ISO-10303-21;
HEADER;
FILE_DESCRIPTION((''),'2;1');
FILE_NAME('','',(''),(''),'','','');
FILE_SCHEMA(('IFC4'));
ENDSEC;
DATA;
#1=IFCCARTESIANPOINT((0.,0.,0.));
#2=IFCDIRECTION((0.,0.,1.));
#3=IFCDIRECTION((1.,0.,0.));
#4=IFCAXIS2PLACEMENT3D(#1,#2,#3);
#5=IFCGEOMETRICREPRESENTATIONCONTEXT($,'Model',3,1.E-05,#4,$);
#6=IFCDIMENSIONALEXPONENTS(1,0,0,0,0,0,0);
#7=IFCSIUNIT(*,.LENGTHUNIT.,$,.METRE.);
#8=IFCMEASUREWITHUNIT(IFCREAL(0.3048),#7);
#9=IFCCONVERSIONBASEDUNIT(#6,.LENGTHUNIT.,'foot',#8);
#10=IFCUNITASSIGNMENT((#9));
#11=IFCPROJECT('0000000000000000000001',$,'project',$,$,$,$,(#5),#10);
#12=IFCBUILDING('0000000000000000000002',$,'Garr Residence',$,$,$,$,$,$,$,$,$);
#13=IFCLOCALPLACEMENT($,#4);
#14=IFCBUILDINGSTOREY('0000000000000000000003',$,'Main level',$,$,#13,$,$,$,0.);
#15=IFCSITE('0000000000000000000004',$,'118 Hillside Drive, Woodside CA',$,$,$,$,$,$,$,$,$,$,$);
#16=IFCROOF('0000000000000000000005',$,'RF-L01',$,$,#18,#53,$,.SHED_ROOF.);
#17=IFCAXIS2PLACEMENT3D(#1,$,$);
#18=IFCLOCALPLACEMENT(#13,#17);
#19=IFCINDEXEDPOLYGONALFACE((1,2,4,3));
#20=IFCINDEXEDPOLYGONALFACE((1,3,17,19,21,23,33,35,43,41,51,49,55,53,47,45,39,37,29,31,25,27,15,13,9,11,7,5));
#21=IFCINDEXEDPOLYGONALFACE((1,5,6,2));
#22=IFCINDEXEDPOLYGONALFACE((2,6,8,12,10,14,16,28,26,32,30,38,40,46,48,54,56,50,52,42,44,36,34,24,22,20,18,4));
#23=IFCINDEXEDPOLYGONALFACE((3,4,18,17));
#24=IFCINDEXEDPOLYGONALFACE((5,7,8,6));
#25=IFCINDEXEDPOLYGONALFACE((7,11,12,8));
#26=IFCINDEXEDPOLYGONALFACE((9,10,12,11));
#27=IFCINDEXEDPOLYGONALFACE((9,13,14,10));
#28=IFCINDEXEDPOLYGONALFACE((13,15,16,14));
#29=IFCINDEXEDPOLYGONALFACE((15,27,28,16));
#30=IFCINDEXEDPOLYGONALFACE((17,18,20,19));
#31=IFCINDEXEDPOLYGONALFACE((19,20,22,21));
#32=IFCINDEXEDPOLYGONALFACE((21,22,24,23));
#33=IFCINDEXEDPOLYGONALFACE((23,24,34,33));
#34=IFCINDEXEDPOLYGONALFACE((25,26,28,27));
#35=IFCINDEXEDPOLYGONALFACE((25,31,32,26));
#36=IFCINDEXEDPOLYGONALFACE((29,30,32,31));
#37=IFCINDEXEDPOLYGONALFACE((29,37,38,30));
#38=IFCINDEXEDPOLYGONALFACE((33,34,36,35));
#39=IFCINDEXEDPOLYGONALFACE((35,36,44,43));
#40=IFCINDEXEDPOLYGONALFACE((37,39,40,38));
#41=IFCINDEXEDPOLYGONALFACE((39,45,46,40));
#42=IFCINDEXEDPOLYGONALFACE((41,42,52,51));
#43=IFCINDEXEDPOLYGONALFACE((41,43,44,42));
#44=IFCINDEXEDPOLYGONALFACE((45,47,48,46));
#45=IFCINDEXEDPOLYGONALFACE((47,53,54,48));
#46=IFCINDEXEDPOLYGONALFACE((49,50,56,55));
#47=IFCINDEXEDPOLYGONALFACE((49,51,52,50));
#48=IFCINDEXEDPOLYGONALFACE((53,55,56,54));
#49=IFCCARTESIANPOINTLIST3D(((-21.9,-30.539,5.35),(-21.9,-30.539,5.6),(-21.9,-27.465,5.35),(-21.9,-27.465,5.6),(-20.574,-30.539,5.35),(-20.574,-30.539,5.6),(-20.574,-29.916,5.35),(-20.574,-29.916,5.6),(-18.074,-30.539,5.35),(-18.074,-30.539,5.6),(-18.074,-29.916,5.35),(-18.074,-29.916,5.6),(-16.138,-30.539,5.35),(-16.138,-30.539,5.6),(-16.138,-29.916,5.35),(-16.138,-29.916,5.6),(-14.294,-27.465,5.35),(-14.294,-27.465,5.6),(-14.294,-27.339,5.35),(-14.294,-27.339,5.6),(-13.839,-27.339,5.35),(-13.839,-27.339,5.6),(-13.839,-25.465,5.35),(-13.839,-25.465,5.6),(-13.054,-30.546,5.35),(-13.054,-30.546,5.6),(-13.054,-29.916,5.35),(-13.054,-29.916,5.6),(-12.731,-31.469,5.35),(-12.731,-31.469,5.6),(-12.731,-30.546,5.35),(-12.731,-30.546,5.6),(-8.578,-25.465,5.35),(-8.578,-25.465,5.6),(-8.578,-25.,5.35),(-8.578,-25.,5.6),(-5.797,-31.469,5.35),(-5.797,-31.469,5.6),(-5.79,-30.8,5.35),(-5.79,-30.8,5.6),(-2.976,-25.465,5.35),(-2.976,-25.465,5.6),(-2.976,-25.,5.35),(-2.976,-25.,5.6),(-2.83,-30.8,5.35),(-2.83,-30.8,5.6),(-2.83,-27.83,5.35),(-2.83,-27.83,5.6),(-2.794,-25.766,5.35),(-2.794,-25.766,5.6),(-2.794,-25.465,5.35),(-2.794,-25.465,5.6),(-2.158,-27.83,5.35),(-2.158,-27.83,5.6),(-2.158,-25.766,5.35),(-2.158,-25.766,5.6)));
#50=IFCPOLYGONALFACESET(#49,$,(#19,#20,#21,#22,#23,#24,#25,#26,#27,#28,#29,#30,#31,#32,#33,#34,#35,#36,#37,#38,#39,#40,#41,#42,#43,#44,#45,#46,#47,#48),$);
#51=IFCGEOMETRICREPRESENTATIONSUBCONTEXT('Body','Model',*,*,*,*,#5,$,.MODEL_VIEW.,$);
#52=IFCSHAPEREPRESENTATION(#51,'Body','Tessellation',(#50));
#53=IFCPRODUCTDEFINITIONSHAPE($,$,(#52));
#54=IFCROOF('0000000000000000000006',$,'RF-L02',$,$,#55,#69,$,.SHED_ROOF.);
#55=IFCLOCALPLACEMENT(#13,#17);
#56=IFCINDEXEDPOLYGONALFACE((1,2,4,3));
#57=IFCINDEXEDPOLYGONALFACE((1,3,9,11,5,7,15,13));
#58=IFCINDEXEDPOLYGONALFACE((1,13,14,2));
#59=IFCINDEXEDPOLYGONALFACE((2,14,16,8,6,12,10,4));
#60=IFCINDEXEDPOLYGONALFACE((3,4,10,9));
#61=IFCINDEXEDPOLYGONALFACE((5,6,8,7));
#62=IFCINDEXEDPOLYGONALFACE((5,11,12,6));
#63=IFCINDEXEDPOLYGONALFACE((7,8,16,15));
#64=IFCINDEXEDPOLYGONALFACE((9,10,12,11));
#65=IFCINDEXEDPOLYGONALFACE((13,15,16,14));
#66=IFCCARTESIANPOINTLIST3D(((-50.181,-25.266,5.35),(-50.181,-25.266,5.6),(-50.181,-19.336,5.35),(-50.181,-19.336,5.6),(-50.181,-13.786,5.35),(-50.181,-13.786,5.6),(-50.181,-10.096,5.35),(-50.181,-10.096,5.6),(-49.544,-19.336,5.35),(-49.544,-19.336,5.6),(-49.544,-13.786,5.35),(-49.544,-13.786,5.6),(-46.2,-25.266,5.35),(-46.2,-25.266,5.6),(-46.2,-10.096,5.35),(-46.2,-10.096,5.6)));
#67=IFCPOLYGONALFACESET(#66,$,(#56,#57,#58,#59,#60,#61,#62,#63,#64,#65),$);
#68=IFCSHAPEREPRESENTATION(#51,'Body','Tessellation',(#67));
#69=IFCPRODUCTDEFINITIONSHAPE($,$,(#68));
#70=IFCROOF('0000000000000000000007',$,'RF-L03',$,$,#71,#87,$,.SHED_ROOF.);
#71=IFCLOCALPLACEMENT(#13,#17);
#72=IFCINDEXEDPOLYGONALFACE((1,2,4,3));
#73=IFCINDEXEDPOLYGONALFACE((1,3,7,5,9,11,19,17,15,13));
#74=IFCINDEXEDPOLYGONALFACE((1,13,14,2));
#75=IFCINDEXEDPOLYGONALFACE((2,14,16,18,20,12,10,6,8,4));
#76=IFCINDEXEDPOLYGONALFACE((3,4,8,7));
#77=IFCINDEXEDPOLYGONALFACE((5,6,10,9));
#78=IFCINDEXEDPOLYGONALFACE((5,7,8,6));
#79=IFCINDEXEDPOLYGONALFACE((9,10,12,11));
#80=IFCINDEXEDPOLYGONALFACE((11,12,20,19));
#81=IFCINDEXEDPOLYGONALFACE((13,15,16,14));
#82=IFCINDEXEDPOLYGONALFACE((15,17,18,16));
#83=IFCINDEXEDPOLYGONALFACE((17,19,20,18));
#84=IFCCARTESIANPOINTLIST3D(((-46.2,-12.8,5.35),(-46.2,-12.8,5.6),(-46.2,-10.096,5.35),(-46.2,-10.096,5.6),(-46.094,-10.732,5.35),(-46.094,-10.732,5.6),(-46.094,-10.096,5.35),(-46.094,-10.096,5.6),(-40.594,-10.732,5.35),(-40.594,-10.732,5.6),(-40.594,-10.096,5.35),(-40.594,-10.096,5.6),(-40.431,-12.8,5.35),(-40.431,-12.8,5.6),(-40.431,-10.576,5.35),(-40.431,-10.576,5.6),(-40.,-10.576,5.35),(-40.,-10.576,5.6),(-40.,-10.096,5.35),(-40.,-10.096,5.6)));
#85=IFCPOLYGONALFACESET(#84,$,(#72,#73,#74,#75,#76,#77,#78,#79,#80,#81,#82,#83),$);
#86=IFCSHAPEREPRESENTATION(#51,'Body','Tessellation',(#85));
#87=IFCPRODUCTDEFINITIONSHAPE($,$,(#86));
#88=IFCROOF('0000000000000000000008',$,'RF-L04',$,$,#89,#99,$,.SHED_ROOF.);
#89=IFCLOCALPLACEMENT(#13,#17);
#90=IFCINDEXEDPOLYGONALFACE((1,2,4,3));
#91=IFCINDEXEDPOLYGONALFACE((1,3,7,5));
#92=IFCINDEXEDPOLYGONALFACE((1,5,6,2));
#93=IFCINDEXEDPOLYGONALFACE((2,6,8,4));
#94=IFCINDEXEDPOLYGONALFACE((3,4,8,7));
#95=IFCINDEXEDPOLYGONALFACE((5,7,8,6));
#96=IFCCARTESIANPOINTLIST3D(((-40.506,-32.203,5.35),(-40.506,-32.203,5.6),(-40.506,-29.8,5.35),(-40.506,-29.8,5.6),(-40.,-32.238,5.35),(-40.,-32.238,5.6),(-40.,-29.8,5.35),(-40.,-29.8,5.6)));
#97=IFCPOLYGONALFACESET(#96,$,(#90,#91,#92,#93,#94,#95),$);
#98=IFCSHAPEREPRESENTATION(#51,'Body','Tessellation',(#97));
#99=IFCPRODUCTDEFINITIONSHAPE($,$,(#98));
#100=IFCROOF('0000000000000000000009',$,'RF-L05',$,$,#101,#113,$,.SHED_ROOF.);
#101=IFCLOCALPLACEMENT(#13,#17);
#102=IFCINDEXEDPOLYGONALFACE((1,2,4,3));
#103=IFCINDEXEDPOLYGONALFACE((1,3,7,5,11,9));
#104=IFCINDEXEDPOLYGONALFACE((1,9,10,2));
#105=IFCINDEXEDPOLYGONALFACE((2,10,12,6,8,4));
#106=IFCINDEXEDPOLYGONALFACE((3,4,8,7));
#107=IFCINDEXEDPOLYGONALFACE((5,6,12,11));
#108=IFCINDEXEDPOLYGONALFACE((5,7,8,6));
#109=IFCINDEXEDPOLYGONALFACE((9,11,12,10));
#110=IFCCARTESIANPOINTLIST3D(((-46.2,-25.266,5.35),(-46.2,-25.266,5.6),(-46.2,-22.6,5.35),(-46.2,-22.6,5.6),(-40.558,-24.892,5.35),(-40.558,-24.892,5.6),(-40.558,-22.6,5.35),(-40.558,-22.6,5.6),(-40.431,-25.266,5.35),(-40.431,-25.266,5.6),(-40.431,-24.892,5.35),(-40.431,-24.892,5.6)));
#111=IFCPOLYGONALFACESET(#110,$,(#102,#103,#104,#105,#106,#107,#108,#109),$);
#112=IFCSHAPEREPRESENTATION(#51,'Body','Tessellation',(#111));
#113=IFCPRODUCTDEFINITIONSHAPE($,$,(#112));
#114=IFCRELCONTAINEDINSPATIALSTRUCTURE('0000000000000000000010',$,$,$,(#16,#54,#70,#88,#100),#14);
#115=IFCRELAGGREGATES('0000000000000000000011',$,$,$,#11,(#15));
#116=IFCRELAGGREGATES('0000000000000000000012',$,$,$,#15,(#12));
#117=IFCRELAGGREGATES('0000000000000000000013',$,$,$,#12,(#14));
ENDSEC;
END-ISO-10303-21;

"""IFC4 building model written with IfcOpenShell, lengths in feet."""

from ifc_helpers import new_model, entity, si_unit, converted_unit, frame, origin, origin_with_axes, place, context, subcontext, project, spatial, polyline, outline, extrude, element, save


model = new_model("IFC4")

# Units and contexts
model_context = context("Model", 3, precision=1e-05, world=origin_with_axes())
body_context = subcontext(model_context, "Body", "Model", "MODEL_VIEW")
ifc_project = project(units=[converted_unit("LENGTHUNIT", "foot", entity("IfcReal", 0.3048), si_unit("LENGTHUNIT", "METRE"), dimensions=[1, 0, 0, 0, 0, 0, 0])], contexts=[model_context])

# Site, building, storey
site = spatial("IfcSite", under=ifc_project, Name="118 Hillside Drive, Woodside CA")
building = spatial("IfcBuilding", under=site, Name="Garr Residence")
storey_placement = place(None, origin_with_axes())
storey = spatial("IfcBuildingStorey", under=building, at=storey_placement, Name="Main level", Elevation=0.0)

# Roofs
roof_1_placement = place(storey_placement, frame((0.0, 0.0, 5.35), z_axis=(0.0, 0.0, 1.0), x_axis=(1.0, 0.0, 0.0)))
element("IfcRoof", 1, at=roof_1_placement, inside=storey, Name="RF-L01", PredefinedType="SHED_ROOF", context=body_context, shape_type="SweptSolid", body=[
    extrude(outline(polyline([(-14.294, -27.465), (-14.294, -27.339), (-13.839, -27.339), (-13.839, -25.465), (-8.578, -25.465), (-8.578, -25.0), (-2.976, -25.0), (-2.976, -25.465), (-2.794, -25.465), (-2.794, -25.766), (-2.158, -25.766), (-2.158, -27.83), (-2.83, -27.83), (-2.83, -30.8), (-5.79, -30.8), (-5.797, -31.469), (-12.731, -31.469), (-12.731, -30.546), (-13.054, -30.546), (-13.054, -29.916), (-16.138, -29.916), (-16.138, -30.539), (-18.074, -30.539), (-18.074, -29.916), (-20.574, -29.916), (-20.574, -30.539), (-21.9, -30.539), (-21.9, -27.465), (-14.294, -27.465)])), origin(), (0.0, 0.0, 1.0), 0.25),
])
roof_2_placement = place(storey_placement, frame((0.0, 0.0, 5.35), z_axis=(0.0, 0.0, 1.0), x_axis=(1.0, 0.0, 0.0)))
element("IfcRoof", 2, at=roof_2_placement, inside=storey, Name="RF-L02", PredefinedType="SHED_ROOF", context=body_context, shape_type="SweptSolid", body=[
    extrude(outline(polyline([(-49.544, -19.336), (-49.544, -13.786), (-50.181, -13.786), (-50.181, -10.096), (-46.2, -10.096), (-46.2, -25.266), (-50.181, -25.266), (-50.181, -19.336), (-49.544, -19.336)])), origin(), (0.0, 0.0, 1.0), 0.25),
])
roof_3_placement = place(storey_placement, frame((0.0, 0.0, 5.35), z_axis=(0.0, 0.0, 1.0), x_axis=(1.0, 0.0, 0.0)))
element("IfcRoof", 3, at=roof_3_placement, inside=storey, Name="RF-L03", PredefinedType="SHED_ROOF", context=body_context, shape_type="SweptSolid", body=[
    extrude(outline(polyline([(-46.094, -10.096), (-46.094, -10.732), (-40.594, -10.732), (-40.594, -10.096), (-40.0, -10.096), (-40.0, -10.576), (-40.431, -10.576), (-40.431, -12.8), (-46.2, -12.8), (-46.2, -10.096), (-46.094, -10.096)])), origin(), (0.0, 0.0, 1.0), 0.25),
])
roof_4_placement = place(storey_placement, frame((0.0, 0.0, 5.35), z_axis=(0.0, 0.0, 1.0), x_axis=(1.0, 0.0, 0.0)))
element("IfcRoof", 4, at=roof_4_placement, inside=storey, Name="RF-L04", PredefinedType="SHED_ROOF", context=body_context, shape_type="SweptSolid", body=[
    extrude(outline(polyline([(-40.506, -32.203), (-40.506, -29.8), (-40.0, -29.8), (-40.0, -32.238), (-40.506, -32.203)])), origin(), (0.0, 0.0, 1.0), 0.25),
])
roof_5_placement = place(storey_placement, frame((0.0, 0.0, 5.35), z_axis=(0.0, 0.0, 1.0), x_axis=(1.0, 0.0, 0.0)))
element("IfcRoof", 5, at=roof_5_placement, inside=storey, Name="RF-L05", PredefinedType="SHED_ROOF", context=body_context, shape_type="SweptSolid", body=[
    extrude(outline(polyline([(-40.558, -22.6), (-40.558, -24.892), (-40.431, -24.892), (-40.431, -25.266), (-46.2, -25.266), (-46.2, -22.6), (-40.558, -22.6)])), origin(), (0.0, 0.0, 1.0), 0.25),
])

save(model, "model.ifc")
